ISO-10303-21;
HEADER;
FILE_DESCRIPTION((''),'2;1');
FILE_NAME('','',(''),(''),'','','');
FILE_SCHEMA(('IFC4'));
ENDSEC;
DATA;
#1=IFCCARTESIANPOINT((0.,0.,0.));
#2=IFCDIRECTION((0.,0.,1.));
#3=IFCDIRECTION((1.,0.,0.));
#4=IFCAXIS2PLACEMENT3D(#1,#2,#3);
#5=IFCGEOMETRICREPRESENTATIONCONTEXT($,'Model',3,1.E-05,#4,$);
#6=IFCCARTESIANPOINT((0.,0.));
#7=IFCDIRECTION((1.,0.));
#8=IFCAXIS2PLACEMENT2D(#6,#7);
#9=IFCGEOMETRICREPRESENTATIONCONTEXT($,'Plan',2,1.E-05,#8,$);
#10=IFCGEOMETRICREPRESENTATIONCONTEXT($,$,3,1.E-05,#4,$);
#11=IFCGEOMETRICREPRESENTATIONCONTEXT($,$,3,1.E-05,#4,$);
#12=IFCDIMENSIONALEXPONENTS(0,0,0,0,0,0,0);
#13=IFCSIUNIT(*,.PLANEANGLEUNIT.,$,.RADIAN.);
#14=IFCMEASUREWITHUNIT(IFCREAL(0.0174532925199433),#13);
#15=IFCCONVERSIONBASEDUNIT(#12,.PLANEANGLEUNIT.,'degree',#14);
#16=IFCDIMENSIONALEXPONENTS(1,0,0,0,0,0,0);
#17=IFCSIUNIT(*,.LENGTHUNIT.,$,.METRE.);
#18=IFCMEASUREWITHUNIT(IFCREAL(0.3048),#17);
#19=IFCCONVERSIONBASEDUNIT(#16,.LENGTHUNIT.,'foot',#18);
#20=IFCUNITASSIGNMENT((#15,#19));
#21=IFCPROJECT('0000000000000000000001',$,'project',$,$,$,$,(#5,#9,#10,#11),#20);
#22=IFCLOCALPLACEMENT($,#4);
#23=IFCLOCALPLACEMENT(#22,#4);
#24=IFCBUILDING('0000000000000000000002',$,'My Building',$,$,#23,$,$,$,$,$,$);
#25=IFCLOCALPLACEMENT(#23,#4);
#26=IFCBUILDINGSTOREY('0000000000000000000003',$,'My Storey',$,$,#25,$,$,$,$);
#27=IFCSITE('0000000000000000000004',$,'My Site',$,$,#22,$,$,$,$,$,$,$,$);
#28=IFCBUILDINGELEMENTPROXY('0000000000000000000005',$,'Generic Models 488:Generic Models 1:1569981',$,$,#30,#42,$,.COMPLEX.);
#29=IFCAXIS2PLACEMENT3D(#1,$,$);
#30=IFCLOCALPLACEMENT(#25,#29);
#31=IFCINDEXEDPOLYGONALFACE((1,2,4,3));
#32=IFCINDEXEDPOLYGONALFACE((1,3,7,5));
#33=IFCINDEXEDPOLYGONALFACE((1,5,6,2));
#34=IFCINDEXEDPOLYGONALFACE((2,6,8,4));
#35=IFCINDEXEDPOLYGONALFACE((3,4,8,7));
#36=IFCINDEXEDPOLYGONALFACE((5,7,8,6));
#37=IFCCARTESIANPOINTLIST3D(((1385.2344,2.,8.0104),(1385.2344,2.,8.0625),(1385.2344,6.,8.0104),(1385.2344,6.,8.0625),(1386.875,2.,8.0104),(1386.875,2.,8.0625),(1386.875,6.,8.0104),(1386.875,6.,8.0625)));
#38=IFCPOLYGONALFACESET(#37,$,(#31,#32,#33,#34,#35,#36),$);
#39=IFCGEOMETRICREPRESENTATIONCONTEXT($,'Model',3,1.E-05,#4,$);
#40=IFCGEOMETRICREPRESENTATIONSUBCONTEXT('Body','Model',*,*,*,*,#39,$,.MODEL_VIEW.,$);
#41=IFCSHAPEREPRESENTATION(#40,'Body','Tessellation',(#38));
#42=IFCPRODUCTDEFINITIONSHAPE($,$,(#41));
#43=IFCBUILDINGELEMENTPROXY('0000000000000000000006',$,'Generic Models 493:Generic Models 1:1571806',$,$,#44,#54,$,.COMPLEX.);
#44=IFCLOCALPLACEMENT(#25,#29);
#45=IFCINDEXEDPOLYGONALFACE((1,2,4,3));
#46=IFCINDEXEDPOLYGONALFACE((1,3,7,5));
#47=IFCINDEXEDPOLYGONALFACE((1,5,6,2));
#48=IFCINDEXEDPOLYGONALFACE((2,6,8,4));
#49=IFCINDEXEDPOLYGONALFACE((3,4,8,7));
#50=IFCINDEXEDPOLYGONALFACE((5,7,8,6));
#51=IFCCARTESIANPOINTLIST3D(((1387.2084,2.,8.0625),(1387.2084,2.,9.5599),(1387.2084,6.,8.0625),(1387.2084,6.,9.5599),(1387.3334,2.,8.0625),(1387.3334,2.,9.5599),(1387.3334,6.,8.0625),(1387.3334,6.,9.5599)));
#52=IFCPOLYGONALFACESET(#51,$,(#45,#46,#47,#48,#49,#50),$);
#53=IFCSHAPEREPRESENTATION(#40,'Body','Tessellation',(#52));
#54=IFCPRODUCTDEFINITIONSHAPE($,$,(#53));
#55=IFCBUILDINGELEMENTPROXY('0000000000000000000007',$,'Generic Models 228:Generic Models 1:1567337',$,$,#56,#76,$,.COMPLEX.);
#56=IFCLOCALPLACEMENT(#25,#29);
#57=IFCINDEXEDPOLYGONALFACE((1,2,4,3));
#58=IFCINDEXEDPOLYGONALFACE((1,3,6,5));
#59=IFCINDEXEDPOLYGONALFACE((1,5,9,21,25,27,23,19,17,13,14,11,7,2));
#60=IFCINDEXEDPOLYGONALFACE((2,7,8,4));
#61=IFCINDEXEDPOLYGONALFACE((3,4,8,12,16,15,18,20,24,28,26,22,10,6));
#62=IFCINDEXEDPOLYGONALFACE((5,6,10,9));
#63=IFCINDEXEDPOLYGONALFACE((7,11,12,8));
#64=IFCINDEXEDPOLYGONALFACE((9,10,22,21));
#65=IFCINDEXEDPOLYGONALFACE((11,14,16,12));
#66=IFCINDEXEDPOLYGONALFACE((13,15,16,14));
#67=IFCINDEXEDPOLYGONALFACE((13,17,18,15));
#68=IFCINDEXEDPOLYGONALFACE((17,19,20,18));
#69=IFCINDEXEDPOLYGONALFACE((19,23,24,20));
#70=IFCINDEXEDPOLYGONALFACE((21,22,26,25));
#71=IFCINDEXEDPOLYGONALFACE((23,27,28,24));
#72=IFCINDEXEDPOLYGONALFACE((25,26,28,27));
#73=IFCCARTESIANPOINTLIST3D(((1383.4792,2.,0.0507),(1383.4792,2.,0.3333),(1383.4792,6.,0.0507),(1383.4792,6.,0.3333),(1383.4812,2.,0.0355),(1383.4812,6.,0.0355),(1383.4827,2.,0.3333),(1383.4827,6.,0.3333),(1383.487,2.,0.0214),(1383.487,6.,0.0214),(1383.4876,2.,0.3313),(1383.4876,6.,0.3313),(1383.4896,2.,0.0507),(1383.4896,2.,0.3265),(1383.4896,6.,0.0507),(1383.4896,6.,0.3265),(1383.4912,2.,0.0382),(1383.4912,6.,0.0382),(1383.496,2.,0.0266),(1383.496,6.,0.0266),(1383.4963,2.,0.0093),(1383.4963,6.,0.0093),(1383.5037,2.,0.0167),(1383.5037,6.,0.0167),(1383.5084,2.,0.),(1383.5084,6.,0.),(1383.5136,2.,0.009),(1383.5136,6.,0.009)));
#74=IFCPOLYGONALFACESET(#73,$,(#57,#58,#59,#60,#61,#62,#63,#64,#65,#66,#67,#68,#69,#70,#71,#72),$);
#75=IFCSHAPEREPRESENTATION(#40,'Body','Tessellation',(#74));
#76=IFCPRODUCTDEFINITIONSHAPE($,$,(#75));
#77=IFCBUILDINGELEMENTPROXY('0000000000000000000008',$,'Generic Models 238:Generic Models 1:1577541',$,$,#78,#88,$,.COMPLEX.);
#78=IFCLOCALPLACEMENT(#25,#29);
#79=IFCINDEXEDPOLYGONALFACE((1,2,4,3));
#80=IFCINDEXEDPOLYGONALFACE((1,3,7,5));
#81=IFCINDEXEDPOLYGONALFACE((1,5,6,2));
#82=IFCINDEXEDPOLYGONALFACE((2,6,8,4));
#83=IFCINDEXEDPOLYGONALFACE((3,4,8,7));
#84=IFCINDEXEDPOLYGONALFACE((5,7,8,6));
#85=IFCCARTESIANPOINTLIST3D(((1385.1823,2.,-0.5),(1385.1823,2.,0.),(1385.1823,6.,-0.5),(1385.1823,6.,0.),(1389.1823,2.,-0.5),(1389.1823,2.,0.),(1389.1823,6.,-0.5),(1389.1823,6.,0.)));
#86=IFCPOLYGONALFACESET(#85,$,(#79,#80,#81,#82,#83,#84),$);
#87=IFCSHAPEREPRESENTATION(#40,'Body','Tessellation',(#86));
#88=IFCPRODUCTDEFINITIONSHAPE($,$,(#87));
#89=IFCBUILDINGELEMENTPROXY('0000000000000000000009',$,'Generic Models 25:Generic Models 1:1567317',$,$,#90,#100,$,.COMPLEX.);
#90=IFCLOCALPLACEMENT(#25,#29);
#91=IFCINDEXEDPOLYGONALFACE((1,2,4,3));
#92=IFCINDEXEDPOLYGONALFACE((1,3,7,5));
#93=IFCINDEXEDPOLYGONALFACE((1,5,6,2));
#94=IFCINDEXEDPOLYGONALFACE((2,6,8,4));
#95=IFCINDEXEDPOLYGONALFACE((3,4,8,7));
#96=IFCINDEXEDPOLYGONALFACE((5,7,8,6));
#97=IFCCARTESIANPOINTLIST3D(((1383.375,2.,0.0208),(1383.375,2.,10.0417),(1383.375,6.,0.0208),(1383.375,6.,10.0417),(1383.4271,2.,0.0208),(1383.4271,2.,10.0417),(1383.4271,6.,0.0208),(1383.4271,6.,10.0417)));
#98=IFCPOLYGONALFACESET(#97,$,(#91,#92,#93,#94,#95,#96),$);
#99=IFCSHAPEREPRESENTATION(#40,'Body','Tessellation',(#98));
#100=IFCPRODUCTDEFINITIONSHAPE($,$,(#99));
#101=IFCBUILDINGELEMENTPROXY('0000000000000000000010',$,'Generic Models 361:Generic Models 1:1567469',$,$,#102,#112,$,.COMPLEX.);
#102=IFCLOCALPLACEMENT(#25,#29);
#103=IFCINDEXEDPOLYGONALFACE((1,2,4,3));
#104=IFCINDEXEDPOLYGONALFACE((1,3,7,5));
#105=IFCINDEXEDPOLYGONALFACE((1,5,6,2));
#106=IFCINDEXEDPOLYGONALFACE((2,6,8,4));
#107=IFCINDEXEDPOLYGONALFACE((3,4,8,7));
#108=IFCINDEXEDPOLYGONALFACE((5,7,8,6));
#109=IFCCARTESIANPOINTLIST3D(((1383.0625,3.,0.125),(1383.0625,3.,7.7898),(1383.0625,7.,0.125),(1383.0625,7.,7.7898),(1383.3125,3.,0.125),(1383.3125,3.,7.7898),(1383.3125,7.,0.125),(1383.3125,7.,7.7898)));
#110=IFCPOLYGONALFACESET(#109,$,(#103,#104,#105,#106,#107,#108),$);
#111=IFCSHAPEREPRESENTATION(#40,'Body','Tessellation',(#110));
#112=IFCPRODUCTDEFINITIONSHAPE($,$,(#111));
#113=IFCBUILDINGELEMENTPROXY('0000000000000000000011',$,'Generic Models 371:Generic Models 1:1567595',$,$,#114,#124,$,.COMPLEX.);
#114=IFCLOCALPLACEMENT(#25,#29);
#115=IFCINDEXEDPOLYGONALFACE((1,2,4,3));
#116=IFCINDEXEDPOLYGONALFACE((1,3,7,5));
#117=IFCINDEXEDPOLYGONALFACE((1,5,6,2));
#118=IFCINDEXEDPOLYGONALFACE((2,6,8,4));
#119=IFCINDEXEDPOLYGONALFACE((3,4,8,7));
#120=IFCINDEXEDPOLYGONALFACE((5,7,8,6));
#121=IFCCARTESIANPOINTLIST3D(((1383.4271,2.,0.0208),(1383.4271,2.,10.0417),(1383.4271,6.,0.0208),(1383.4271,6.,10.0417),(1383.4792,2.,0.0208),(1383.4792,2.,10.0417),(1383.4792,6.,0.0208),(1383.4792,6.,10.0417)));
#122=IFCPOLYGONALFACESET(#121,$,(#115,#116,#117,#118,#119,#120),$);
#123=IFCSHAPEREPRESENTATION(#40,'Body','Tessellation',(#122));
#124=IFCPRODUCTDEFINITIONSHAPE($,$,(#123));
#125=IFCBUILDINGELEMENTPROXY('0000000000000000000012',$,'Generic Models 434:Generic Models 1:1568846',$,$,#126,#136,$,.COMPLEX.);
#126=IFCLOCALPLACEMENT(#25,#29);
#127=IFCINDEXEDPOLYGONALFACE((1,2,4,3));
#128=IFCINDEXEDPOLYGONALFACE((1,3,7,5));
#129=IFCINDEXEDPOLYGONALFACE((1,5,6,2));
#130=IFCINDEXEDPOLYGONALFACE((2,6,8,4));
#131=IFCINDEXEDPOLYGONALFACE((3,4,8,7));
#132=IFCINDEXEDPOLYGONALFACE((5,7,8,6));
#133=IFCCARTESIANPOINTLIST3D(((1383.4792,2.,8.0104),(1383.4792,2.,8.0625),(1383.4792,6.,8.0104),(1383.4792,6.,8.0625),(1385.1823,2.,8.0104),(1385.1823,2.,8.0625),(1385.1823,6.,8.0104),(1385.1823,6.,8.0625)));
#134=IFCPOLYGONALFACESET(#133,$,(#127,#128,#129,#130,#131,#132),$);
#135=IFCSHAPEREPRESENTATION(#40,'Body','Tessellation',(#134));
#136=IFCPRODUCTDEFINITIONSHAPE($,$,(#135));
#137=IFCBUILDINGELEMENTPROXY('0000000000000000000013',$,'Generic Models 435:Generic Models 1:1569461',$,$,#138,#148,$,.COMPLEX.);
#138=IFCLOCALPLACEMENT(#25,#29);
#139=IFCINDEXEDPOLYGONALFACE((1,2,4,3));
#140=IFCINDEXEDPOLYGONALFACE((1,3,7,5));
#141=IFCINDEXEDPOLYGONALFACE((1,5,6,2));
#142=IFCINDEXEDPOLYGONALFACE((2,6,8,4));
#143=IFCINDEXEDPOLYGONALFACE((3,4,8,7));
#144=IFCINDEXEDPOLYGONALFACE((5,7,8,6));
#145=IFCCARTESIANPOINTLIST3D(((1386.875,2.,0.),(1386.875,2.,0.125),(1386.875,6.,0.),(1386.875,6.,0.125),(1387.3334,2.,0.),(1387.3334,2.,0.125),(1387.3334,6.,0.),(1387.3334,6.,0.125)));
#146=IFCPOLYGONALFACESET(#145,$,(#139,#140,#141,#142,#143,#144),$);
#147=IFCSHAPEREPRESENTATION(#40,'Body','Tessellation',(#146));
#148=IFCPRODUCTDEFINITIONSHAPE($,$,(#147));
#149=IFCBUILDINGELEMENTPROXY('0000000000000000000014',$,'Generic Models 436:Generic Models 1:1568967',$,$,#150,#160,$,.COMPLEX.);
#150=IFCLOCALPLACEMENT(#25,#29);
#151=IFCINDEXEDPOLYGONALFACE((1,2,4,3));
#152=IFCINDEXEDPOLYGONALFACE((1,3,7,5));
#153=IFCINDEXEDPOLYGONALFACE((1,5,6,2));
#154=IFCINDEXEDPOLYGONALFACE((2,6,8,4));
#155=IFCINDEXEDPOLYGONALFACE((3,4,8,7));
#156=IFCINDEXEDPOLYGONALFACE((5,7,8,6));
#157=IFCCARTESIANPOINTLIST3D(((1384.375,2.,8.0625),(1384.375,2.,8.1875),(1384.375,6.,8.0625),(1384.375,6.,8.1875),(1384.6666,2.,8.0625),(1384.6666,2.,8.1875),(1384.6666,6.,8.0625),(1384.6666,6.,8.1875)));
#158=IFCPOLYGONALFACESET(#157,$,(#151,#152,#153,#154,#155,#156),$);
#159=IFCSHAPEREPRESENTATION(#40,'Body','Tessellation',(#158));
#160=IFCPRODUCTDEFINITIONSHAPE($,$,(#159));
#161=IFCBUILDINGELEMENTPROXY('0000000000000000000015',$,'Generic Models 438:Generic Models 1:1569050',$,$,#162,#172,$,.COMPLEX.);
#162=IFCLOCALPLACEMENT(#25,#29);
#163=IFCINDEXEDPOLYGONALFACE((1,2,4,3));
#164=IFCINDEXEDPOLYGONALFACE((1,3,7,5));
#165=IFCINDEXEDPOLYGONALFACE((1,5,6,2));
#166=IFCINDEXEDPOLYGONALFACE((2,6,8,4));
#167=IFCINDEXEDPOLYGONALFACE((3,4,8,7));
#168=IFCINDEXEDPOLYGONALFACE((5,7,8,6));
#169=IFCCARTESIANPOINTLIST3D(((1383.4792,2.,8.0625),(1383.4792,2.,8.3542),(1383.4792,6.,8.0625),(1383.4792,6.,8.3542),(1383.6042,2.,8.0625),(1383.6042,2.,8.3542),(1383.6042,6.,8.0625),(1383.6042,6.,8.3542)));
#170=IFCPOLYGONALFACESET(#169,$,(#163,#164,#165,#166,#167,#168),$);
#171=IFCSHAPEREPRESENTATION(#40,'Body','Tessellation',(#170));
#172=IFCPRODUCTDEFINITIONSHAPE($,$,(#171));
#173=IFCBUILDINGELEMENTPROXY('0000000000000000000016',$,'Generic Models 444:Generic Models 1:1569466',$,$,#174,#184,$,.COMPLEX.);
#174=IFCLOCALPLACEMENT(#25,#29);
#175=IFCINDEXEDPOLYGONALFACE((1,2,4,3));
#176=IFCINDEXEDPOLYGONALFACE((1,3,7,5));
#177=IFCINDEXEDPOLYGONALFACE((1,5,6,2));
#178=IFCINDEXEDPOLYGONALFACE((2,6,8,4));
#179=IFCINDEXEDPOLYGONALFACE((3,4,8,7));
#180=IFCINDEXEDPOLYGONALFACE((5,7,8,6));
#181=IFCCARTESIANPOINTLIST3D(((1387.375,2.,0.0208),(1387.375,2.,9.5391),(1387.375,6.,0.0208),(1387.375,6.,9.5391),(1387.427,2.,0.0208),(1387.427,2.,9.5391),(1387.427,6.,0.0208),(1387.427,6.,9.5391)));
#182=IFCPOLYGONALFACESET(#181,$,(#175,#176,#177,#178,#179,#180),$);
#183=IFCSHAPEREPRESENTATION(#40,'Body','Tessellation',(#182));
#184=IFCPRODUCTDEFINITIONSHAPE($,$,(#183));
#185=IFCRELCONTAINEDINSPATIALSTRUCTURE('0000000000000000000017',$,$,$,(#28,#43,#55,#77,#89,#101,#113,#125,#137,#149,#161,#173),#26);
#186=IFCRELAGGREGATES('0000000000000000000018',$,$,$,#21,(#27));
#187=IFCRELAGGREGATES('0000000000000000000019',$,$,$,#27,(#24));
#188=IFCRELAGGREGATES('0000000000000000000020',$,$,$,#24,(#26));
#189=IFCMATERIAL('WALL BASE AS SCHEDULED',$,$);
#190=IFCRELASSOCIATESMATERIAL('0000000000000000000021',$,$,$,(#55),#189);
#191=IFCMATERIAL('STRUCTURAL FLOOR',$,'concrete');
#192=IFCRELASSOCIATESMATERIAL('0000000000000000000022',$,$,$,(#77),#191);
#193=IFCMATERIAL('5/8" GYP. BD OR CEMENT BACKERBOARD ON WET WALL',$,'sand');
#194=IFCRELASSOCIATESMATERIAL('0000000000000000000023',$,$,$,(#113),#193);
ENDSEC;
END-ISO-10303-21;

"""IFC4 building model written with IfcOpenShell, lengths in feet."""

from ifc_helpers import new_model, entity, si_unit, converted_unit, frame, origin_with_axes, origin_2d_with_axis, place, context, subcontext, project, spatial, polyline, outline, extrude, material, element, save


model = new_model("IFC4")

# Units and contexts
model_context_1 = context("Model", 3, precision=1e-05, world=origin_with_axes())
plan_context = context("Plan", 2, precision=1e-05, world=origin_2d_with_axis())
model_context_2 = context("Model", 3, precision=1e-05, world=origin_with_axes())
context_of_model_1 = context(None, 3, precision=1e-05, world=origin_with_axes())
context_of_model_2 = context(None, 3, precision=1e-05, world=origin_with_axes())
body_context = subcontext(model_context_2, "Body", "Model", "MODEL_VIEW")
ifc_project = project(units=[converted_unit("PLANEANGLEUNIT", "degree", entity("IfcReal", 0.0174532925199433), si_unit("PLANEANGLEUNIT", "RADIAN"), dimensions=[0, 0, 0, 0, 0, 0, 0]), converted_unit("LENGTHUNIT", "foot", entity("IfcReal", 0.3048), si_unit("LENGTHUNIT", "METRE"), dimensions=[1, 0, 0, 0, 0, 0, 0])], contexts=[model_context_1, plan_context, context_of_model_1, context_of_model_2])

# Site, building, storey
site_placement = place(None, origin_with_axes())
site = spatial("IfcSite", under=ifc_project, at=site_placement, Name="My Site")
building_placement = place(site_placement, origin_with_axes())
building = spatial("IfcBuilding", under=site, at=building_placement, Name="My Building")
storey_placement = place(building_placement, origin_with_axes())
storey = spatial("IfcBuildingStorey", under=building, at=storey_placement, Name="My Storey")

# Building element proxies
proxy_1_placement = place(storey_placement, frame((1385.2344, 6.0, 8.0104), z_axis=(0.0, -1.0, 0.0), x_axis=(0.0, 0.0, 1.0)))
element("IfcBuildingElementProxy", 1, at=proxy_1_placement, inside=storey, Name="Generic Models 488:Generic Models 1:1569981", PredefinedType="COMPLEX", context=body_context, shape_type="SweptSolid", body=[
    extrude(outline(polyline([(-0.026, -0.8203), (0.026, -0.8203), (0.026, 0.8203), (-0.026, 0.8203), (-0.026, -0.8203)])), frame((0.026, -0.8203, 0.0), z_axis=(0.0, 0.0, -1.0), x_axis=(1.0, 0.0, 0.0)), (0.0, 0.0, -1.0), 4.0),
])
proxy_2_placement = place(storey_placement, frame((1387.2084, 6.0, 8.0625), z_axis=(0.0, -1.0, 0.0), x_axis=(0.0, 0.0, 1.0)))
element("IfcBuildingElementProxy", 2, at=proxy_2_placement, inside=storey, Name="Generic Models 493:Generic Models 1:1571806", PredefinedType="COMPLEX", context=body_context, shape_type="SweptSolid", body=[
    extrude(outline(polyline([(-0.7487, -0.0625), (0.7487, -0.0625), (0.7487, 0.0625), (-0.7487, 0.0625), (-0.7487, -0.0625)])), frame((0.7487, -0.0625, 0.0), z_axis=(0.0, 0.0, -1.0), x_axis=(-1.0, 0.0, 0.0)), (0.0, 0.0, -1.0), 4.0),
])
ifc_material_1 = material(Name="WALL BASE AS SCHEDULED")
proxy_3_placement = place(storey_placement, frame((1383.4792, 6.0, 0.0), z_axis=(0.0, -1.0, 0.0), x_axis=(0.0, 0.0, 1.0)))
element("IfcBuildingElementProxy", 3, at=proxy_3_placement, inside=storey, material=ifc_material_1, Name="Generic Models 228:Generic Models 1:1567337", PredefinedType="COMPLEX", context=body_context, shape_type="SweptSolid", body=[
    extrude(outline(polyline([(0.2206, 0.0), (0.2204, 0.0036), (0.2182, 0.0083), (0.2132, 0.01), (-0.0621, -0.0058), (-0.0747, -0.0049), (-0.0865, -0.0007), (-0.0969, 0.0063), (-0.1051, 0.0158), (-0.1138, 0.0101), (-0.1038, -0.0014), (-0.0912, -0.01), (-0.0768, -0.0151), (-0.0615, -0.0162), (0.2206, 0.0)])), frame((0.113, -0.0126, 0.0), z_axis=(0.0, 0.0, -1.0), x_axis=(0.998358, 0.057286, 0.0)), (0.0, 0.0, -1.0), 4.0),
])
ifc_material_2 = material(Name="STRUCTURAL FLOOR", Category="concrete")
proxy_4_placement = place(storey_placement, frame((1385.1823, 6.0, -0.5), z_axis=(0.0, -1.0, 0.0), x_axis=(0.0, 0.0, 1.0)))
element("IfcBuildingElementProxy", 4, at=proxy_4_placement, inside=storey, material=ifc_material_2, Name="Generic Models 238:Generic Models 1:1577541", PredefinedType="COMPLEX", context=body_context, shape_type="SweptSolid", body=[
    extrude(outline(polyline([(-0.25, -2.0), (0.25, -2.0), (0.25, 2.0), (-0.25, 2.0), (-0.25, -2.0)])), frame((0.25, -2.0, 0.0), z_axis=(0.0, 0.0, -1.0), x_axis=(1.0, 0.0, 0.0)), (0.0, 0.0, -1.0), 4.0),
])
proxy_5_placement = place(storey_placement, frame((1383.375, 6.0, 0.0208), z_axis=(0.0, -1.0, 0.0), x_axis=(0.0, 0.0, 1.0)))
element("IfcBuildingElementProxy", 5, at=proxy_5_placement, inside=storey, Name="Generic Models 25:Generic Models 1:1567317", PredefinedType="COMPLEX", context=body_context, shape_type="SweptSolid", body=[
    extrude(outline(polyline([(-5.0104, -0.026), (5.0104, -0.026), (5.0104, 0.026), (-5.0104, 0.026), (-5.0104, -0.026)])), frame((5.0104, -0.026, 0.0), z_axis=(0.0, 0.0, -1.0), x_axis=(1.0, 0.0, 0.0)), (0.0, 0.0, -1.0), 4.0),
])
proxy_6_placement = place(storey_placement, frame((1383.0625, 7.0, 0.125), z_axis=(0.0, -1.0, 0.0), x_axis=(0.0, 0.0, 1.0)))
element("IfcBuildingElementProxy", 6, at=proxy_6_placement, inside=storey, Name="Generic Models 361:Generic Models 1:1567469", PredefinedType="COMPLEX", context=body_context, shape_type="SweptSolid", body=[
    extrude(outline(polyline([(-0.125, -3.8324), (0.125, -3.8324), (0.125, 3.8324), (-0.125, 3.8324), (-0.125, -3.8324)])), frame((3.8324, -0.125, 0.0), z_axis=(0.0, 0.0, -1.0), x_axis=(0.0, 1.0, 0.0)), (0.0, 0.0, -1.0), 4.0),
])
ifc_material_3 = material(Name="5/8\" GYP. BD OR CEMENT BACKERBOARD ON WET WALL", Category="sand")
proxy_7_placement = place(storey_placement, frame((1383.4271, 6.0, 0.0208), z_axis=(0.0, -1.0, 0.0), x_axis=(0.0, 0.0, 1.0)))
element("IfcBuildingElementProxy", 7, at=proxy_7_placement, inside=storey, material=ifc_material_3, Name="Generic Models 371:Generic Models 1:1567595", PredefinedType="COMPLEX", context=body_context, shape_type="SweptSolid", body=[
    extrude(outline(polyline([(-5.0104, -0.026), (5.0104, -0.026), (5.0104, 0.026), (-5.0104, 0.026), (-5.0104, -0.026)])), frame((5.0104, -0.026, 0.0), z_axis=(0.0, 0.0, -1.0), x_axis=(1.0, 0.0, 0.0)), (0.0, 0.0, -1.0), 4.0),
])
proxy_8_placement = place(storey_placement, frame((1383.4792, 6.0, 8.0104), z_axis=(0.0, -1.0, 0.0), x_axis=(0.0, 0.0, 1.0)))
element("IfcBuildingElementProxy", 8, at=proxy_8_placement, inside=storey, Name="Generic Models 434:Generic Models 1:1568846", PredefinedType="COMPLEX", context=body_context, shape_type="SweptSolid", body=[
    extrude(outline(polyline([(-0.026, -0.8516), (0.026, -0.8516), (0.026, 0.8516), (-0.026, 0.8516), (-0.026, -0.8516)])), frame((0.026, -0.8516, 0.0), z_axis=(0.0, 0.0, -1.0), x_axis=(-1.0, 0.0, 0.0)), (0.0, 0.0, -1.0), 4.0),
])
proxy_9_placement = place(storey_placement, frame((1386.875, 6.0, 0.0), z_axis=(0.0, -1.0, 0.0), x_axis=(0.0, 0.0, 1.0)))
element("IfcBuildingElementProxy", 9, at=proxy_9_placement, inside=storey, Name="Generic Models 435:Generic Models 1:1569461", PredefinedType="COMPLEX", context=body_context, shape_type="SweptSolid", body=[
    extrude(outline(polyline([(-0.2292, -0.0625), (0.2292, -0.0625), (0.2292, 0.0625), (-0.2292, 0.0625), (-0.2292, -0.0625)])), frame((0.0625, -0.2292, 0.0), z_axis=(0.0, 0.0, -1.0), x_axis=(0.0, 1.0, 0.0)), (0.0, 0.0, -1.0), 4.0),
])
proxy_10_placement = place(storey_placement, frame((1384.375, 6.0, 8.0625), z_axis=(0.0, -1.0, 0.0), x_axis=(0.0, 0.0, 1.0)))
element("IfcBuildingElementProxy", 10, at=proxy_10_placement, inside=storey, Name="Generic Models 436:Generic Models 1:1568967", PredefinedType="COMPLEX", context=body_context, shape_type="SweptSolid", body=[
    extrude(outline(polyline([(-0.0625, -0.1458), (0.0625, -0.1458), (0.0625, 0.1458), (-0.0625, 0.1458), (-0.0625, -0.1458)])), frame((0.0625, -0.1458, 0.0), z_axis=(0.0, 0.0, -1.0), x_axis=(-1.0, 0.0, 0.0)), (0.0, 0.0, -1.0), 4.0),
])
proxy_11_placement = place(storey_placement, frame((1383.4792, 6.0, 8.0625), z_axis=(0.0, -1.0, 0.0), x_axis=(0.0, 0.0, 1.0)))
element("IfcBuildingElementProxy", 11, at=proxy_11_placement, inside=storey, Name="Generic Models 438:Generic Models 1:1569050", PredefinedType="COMPLEX", context=body_context, shape_type="SweptSolid", body=[
    extrude(outline(polyline([(-0.1458, -0.0625), (0.1458, -0.0625), (0.1458, 0.0625), (-0.1458, 0.0625), (-0.1458, -0.0625)])), frame((0.1458, -0.0625, 0.0), z_axis=(0.0, 0.0, -1.0), x_axis=(-1.0, 0.0, 0.0)), (0.0, 0.0, -1.0), 4.0),
])
proxy_12_placement = place(storey_placement, frame((1387.375, 6.0, 0.0208), z_axis=(0.0, -1.0, 0.0), x_axis=(0.0, 0.0, 1.0)))
element("IfcBuildingElementProxy", 12, at=proxy_12_placement, inside=storey, Name="Generic Models 444:Generic Models 1:1569466", PredefinedType="COMPLEX", context=body_context, shape_type="SweptSolid", body=[
    extrude(outline(polyline([(-4.7591, -0.026), (4.7591, -0.026), (4.7591, 0.026), (-4.7591, 0.026), (-4.7591, -0.026)])), frame((4.7591, -0.026, 0.0), z_axis=(0.0, 0.0, -1.0), x_axis=(1.0, 0.0, 0.0)), (0.0, 0.0, -1.0), 4.0),
])

save(model, "model.ifc")
